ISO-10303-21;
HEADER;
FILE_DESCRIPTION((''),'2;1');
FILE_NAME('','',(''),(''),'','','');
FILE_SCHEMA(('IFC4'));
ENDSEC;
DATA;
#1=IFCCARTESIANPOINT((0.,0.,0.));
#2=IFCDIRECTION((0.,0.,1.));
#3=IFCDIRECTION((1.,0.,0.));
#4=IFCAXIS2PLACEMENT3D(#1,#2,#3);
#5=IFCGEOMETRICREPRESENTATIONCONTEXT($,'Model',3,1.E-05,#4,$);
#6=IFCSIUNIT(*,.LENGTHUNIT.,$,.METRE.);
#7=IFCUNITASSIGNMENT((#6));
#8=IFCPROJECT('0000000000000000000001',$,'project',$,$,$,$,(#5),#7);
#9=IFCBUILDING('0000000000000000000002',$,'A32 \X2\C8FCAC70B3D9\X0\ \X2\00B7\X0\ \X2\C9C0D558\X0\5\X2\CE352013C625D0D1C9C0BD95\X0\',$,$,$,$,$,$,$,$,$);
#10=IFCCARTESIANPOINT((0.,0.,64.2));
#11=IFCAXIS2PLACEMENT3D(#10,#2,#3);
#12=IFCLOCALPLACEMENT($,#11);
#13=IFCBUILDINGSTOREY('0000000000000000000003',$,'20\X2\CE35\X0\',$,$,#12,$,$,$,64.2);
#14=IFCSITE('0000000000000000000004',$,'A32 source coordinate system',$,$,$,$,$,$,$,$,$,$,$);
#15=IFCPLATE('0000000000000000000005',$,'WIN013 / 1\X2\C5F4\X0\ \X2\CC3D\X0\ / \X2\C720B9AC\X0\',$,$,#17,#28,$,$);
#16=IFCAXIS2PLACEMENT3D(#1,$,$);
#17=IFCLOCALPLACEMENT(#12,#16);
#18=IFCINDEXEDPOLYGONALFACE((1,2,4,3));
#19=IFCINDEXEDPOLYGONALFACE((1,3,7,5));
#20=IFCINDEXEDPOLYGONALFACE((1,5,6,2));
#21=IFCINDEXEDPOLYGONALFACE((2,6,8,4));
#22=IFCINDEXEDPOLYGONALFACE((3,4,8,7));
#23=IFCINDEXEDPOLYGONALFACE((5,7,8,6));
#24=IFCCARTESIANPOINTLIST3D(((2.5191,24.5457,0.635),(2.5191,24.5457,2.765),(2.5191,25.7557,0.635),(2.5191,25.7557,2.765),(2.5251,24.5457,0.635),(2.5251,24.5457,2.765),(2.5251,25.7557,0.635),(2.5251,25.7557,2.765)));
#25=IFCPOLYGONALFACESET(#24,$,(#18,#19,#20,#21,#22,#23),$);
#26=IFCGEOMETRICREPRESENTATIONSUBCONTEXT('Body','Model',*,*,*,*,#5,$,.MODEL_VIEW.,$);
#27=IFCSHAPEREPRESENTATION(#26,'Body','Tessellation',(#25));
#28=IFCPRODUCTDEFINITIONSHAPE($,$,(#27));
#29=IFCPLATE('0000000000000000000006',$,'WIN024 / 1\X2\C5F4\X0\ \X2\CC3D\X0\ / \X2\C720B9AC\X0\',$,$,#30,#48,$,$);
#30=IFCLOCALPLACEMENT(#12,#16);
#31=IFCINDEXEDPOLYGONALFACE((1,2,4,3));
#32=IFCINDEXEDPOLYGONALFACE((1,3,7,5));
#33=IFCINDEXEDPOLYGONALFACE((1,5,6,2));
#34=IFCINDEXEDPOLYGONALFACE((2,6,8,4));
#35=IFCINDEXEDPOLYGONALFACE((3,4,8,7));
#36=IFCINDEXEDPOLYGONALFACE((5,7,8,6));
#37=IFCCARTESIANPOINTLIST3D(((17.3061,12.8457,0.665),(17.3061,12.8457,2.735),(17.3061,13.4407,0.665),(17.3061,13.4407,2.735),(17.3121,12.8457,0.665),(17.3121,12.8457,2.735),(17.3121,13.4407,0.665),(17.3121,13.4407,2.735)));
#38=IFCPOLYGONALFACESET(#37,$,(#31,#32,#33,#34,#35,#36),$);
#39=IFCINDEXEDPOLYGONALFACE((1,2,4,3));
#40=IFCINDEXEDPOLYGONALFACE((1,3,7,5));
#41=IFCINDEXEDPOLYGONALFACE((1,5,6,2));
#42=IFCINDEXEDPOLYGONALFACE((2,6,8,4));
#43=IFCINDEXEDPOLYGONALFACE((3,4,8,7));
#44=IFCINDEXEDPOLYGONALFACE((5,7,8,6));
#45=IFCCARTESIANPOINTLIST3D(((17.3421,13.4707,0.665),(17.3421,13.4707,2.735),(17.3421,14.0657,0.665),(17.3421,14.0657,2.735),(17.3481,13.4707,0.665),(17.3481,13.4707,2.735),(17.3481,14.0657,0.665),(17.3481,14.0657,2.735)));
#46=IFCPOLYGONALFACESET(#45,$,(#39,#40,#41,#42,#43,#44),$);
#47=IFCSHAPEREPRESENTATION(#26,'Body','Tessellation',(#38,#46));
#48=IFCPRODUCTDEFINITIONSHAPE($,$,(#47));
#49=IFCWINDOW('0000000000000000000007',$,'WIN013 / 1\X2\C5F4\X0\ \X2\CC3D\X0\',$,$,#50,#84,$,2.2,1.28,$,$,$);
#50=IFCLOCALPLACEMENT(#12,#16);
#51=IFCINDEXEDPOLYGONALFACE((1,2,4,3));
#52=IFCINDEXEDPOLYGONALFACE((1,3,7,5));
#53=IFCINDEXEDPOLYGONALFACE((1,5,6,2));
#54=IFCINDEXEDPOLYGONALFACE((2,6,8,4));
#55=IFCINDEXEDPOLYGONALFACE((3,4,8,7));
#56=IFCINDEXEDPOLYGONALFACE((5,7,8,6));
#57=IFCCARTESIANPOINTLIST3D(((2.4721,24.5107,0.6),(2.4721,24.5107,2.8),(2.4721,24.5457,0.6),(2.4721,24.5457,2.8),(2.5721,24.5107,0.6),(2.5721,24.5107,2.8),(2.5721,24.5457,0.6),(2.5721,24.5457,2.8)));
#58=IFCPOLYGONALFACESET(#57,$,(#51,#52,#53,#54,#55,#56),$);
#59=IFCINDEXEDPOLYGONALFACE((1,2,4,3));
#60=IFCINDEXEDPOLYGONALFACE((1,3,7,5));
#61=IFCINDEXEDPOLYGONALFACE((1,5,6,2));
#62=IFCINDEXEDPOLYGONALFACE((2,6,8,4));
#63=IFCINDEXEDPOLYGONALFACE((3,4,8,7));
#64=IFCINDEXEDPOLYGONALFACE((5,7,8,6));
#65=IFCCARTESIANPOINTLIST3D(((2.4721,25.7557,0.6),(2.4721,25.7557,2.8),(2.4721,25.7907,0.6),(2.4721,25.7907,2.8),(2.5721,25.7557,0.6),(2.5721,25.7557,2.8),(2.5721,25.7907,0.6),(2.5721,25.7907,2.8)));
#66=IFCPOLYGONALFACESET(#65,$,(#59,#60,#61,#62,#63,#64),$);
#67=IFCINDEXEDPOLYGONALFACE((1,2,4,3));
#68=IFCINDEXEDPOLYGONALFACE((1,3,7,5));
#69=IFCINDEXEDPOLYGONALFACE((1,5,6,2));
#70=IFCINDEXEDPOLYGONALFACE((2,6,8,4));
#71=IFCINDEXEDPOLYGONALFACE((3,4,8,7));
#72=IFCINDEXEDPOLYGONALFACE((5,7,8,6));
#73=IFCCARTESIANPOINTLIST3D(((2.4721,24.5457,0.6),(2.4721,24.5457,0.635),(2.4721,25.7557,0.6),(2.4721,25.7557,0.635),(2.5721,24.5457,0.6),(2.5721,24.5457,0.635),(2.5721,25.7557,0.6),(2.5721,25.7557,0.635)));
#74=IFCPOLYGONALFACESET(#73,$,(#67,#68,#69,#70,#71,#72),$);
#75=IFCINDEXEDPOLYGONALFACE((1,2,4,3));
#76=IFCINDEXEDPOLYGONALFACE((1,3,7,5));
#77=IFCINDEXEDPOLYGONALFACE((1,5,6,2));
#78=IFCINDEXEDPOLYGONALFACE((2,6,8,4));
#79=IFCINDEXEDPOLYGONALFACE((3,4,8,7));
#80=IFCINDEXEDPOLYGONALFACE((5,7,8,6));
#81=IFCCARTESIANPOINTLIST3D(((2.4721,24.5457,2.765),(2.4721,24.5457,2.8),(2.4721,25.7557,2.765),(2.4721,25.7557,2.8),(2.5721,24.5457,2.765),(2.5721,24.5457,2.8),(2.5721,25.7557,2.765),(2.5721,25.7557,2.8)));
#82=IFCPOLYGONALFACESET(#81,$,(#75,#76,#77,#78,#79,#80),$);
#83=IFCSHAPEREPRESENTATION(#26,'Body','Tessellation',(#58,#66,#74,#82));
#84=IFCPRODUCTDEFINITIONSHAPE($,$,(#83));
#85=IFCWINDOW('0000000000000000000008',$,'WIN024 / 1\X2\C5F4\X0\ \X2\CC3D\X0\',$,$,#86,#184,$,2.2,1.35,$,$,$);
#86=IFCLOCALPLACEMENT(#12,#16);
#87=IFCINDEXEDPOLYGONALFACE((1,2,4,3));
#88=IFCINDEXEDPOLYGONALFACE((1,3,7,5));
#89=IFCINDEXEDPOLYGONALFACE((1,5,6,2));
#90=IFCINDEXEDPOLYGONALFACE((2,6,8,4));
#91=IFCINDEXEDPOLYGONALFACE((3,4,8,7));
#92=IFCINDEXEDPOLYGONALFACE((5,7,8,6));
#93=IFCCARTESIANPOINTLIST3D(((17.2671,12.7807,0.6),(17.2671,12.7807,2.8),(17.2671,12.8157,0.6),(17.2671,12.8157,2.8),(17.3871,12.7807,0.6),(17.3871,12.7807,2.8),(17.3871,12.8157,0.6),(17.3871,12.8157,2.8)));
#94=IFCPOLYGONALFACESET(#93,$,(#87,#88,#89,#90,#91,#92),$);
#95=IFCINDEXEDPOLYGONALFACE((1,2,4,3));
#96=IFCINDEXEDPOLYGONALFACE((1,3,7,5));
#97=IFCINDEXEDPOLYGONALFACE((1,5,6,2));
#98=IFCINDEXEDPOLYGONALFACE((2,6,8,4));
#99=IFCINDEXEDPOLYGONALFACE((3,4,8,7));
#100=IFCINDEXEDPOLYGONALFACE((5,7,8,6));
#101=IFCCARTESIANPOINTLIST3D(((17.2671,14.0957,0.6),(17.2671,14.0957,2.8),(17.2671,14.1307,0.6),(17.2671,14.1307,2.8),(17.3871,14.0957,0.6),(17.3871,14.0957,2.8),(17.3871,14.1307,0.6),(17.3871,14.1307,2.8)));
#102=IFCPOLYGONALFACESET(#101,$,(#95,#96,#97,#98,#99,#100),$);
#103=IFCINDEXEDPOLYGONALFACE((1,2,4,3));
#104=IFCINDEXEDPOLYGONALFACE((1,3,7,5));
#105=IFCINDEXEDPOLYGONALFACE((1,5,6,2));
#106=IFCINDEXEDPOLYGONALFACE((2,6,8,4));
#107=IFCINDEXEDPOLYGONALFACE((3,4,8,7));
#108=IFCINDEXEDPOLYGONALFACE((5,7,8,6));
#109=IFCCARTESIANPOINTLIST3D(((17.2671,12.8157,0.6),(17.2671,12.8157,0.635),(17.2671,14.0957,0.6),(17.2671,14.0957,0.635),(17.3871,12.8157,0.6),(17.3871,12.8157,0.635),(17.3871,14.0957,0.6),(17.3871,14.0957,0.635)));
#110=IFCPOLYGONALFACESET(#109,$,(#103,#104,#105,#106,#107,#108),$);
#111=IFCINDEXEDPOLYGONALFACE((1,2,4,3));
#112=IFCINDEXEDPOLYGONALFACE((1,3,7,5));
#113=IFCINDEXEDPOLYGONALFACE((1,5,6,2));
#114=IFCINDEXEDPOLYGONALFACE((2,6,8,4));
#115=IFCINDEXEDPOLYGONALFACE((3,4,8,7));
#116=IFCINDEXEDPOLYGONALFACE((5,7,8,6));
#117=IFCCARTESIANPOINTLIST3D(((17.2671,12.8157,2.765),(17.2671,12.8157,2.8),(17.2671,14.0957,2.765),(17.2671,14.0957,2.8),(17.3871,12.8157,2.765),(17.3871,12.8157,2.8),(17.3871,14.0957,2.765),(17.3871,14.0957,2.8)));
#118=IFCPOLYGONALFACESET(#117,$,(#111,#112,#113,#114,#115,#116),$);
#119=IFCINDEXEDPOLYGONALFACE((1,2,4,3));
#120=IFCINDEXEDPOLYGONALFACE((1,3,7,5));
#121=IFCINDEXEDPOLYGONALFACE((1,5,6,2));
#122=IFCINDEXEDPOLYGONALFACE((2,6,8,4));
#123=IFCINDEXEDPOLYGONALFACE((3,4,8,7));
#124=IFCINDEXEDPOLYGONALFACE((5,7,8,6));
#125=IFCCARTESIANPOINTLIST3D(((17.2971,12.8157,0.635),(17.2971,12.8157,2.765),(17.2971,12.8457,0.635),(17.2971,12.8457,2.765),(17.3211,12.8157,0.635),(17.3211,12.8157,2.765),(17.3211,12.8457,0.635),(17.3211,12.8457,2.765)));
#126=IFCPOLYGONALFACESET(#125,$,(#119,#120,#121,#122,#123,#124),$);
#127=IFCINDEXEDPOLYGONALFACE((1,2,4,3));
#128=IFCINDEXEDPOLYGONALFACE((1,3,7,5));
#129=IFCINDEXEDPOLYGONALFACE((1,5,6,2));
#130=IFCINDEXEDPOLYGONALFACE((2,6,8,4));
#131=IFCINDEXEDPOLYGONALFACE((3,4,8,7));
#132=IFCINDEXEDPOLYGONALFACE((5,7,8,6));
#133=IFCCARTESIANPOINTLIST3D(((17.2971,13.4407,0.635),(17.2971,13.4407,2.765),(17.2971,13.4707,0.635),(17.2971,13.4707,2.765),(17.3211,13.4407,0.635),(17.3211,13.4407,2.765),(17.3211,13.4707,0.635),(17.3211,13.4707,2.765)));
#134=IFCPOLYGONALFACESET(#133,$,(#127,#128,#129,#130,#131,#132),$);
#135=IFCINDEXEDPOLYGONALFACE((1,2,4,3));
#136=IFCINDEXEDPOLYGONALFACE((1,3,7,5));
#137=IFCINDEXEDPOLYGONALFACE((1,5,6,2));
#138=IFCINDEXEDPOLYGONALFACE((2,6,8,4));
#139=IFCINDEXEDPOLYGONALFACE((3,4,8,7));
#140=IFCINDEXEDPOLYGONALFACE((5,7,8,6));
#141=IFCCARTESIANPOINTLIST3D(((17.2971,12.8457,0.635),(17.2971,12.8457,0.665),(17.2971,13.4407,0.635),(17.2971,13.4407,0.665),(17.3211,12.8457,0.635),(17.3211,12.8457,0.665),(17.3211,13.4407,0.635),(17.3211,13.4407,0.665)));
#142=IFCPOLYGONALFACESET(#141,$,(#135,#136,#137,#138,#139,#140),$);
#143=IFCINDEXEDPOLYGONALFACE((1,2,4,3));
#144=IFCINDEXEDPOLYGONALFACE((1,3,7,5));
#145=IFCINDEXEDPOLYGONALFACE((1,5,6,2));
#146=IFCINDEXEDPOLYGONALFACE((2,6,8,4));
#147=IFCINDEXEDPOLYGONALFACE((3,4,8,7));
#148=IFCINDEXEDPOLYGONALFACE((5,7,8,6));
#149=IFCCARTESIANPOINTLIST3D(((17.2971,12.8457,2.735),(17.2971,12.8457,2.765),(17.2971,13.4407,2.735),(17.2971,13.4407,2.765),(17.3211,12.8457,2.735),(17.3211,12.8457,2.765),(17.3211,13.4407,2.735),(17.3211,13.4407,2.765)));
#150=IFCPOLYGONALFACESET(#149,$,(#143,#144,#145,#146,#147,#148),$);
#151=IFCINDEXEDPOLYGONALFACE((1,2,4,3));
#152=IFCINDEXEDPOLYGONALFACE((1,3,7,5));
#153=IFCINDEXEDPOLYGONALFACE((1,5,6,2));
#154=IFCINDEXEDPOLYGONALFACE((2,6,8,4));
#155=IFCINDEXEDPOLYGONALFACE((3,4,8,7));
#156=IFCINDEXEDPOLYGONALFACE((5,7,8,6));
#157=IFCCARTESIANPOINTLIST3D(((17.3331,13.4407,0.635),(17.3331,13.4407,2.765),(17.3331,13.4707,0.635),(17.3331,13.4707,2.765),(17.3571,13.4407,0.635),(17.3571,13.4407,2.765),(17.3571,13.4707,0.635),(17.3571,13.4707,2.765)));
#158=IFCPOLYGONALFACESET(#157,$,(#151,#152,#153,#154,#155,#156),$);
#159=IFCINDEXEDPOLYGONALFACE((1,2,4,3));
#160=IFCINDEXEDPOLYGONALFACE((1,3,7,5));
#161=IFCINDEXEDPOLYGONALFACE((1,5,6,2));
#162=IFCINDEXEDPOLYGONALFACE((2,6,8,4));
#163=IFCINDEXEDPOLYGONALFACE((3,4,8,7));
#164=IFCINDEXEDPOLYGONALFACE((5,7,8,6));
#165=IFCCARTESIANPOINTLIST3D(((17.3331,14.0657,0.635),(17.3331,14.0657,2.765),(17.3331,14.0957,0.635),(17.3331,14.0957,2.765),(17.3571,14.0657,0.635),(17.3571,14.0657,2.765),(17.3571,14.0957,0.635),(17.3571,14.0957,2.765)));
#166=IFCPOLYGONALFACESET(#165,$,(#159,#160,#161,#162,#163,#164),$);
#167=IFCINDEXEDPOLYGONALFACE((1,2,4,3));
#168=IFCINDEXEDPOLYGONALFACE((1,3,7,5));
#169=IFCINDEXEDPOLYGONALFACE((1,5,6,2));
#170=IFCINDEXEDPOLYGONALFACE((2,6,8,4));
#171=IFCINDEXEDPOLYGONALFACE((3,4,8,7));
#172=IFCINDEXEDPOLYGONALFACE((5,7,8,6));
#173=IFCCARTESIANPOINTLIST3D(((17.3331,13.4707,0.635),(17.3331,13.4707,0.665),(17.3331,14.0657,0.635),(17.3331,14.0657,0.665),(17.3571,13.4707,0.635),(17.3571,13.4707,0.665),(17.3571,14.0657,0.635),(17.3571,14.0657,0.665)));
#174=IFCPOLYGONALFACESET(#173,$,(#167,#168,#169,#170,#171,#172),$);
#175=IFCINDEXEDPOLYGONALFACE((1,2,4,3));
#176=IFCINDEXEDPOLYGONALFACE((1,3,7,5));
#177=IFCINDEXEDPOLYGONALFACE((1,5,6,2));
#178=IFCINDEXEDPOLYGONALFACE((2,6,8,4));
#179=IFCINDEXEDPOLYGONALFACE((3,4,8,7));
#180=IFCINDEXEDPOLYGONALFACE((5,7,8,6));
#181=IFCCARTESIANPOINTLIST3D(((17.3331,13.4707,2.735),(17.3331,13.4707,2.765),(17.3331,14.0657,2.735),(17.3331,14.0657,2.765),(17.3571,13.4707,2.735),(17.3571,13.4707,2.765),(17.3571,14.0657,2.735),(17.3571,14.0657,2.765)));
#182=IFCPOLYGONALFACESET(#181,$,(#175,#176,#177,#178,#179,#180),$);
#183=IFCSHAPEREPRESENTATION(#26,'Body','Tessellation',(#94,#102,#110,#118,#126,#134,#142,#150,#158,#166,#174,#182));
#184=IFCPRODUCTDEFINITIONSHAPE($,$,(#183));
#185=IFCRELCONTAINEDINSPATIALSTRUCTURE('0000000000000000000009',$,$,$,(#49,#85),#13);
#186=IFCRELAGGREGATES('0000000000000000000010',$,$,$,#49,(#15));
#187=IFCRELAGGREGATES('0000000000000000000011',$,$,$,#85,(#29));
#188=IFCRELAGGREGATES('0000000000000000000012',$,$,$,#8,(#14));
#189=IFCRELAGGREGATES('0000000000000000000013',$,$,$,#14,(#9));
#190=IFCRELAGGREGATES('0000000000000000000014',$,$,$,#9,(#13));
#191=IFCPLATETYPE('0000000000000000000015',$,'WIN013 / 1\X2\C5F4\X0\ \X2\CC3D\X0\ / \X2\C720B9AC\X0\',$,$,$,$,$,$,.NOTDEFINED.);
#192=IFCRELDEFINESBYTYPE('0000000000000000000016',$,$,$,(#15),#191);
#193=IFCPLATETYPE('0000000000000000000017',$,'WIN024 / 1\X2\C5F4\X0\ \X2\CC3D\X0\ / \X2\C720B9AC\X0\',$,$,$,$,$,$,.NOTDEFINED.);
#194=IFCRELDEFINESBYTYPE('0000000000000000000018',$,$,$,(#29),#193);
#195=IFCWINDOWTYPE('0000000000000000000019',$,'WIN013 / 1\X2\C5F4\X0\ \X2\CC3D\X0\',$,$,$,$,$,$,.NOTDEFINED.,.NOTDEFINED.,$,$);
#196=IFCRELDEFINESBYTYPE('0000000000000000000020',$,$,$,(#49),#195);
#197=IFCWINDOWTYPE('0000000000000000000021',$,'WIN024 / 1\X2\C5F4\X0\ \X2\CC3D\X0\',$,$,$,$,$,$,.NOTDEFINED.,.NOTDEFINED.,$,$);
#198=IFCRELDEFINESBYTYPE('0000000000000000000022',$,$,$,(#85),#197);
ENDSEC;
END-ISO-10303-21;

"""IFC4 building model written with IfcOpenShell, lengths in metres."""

from ifc_helpers import new_model, si_unit, frame, origin, origin_with_axes, place, context, subcontext, project, spatial, polyline, outline, extrude, source, transform, mapped, type_object, type_shapes, element, aggregate, save


model = new_model("IFC4")

# Units and contexts
model_context = context("Model", 3, precision=1e-05, world=origin_with_axes())
body_context = subcontext(model_context, "Body", "Model", "MODEL_VIEW")
ifc_project = project(units=[si_unit("LENGTHUNIT", "METRE")], contexts=[model_context])

# Plates
plate_type_1 = type_object("IfcPlateType", Name="WIN013 / 1열 창 / 유리", PredefinedType="NOTDEFINED")
shared_shape_1 = source(origin(), body_context, "Body", "SweptSolid", [
    extrude(outline(polyline([(2.5191, 24.5457), (2.5191, 25.7557), (2.5251, 25.7557), (2.5251, 24.5457), (2.5191, 24.5457)])), frame((0.0, 0.0, 0.635)), (0.0, 0.0, 1.0), 2.13),
])
type_shapes(plate_type_1, [shared_shape_1])
storey_placement = place(None, frame((0.0, 0.0, 64.2), z_axis=(0.0, 0.0, 1.0), x_axis=(1.0, 0.0, 0.0)))
window_1_placement = place(storey_placement, origin_with_axes())
plate_1_placement = place(window_1_placement, origin_with_axes())
plate_1 = element("IfcPlate", 1, at=plate_1_placement, type_object=plate_type_1, Name="WIN013 / 1열 창 / 유리", context=body_context, shape_type="MappedRepresentation", body=[
    mapped(shared_shape_1, transform((0.0, 0.0, 0.0), scale=1.0)),
])
plate_type_2 = type_object("IfcPlateType", Name="WIN024 / 1열 창 / 유리", PredefinedType="NOTDEFINED")
shared_shape_2 = source(origin(), body_context, "Body", "SweptSolid", [
    extrude(outline(polyline([(17.3061, 12.8457), (17.3061, 13.4407), (17.3121, 13.4407), (17.3121, 12.8457), (17.3061, 12.8457)])), frame((0.0, 0.0, 0.665)), (0.0, 0.0, 1.0), 2.07),
    extrude(outline(polyline([(17.3421, 13.4707), (17.3421, 14.0657), (17.3481, 14.0657), (17.3481, 13.4707), (17.3421, 13.4707)])), frame((0.0, 0.0, 0.665)), (0.0, 0.0, 1.0), 2.07),
])
type_shapes(plate_type_2, [shared_shape_2])
window_2_placement = place(storey_placement, origin_with_axes())
plate_2_placement = place(window_2_placement, origin_with_axes())
plate_2 = element("IfcPlate", 2, at=plate_2_placement, type_object=plate_type_2, Name="WIN024 / 1열 창 / 유리", context=body_context, shape_type="MappedRepresentation", body=[
    mapped(shared_shape_2, transform((0.0, 0.0, 0.0), scale=1.0)),
])

# Site, building, storey
site = spatial("IfcSite", under=ifc_project, Name="A32 source coordinate system")
building = spatial("IfcBuilding", under=site, Name="A32 주거동 · 지하5층–옥탑지붕")
storey = spatial("IfcBuildingStorey", under=building, at=storey_placement, Name="20층", Elevation=64.2)

# Windows
window_type_1 = type_object("IfcWindowType", Name="WIN013 / 1열 창", PartitioningType="NOTDEFINED", PredefinedType="NOTDEFINED")
shared_shape_3 = source(origin(), body_context, "Body", "SweptSolid", [
    extrude(outline(polyline([(2.4721, 24.5107), (2.4721, 24.5457), (2.5721, 24.5457), (2.5721, 24.5107), (2.4721, 24.5107)])), frame((0.0, 0.0, 0.6)), (0.0, 0.0, 1.0), 2.2),
    extrude(outline(polyline([(2.4721, 25.7557), (2.4721, 25.7907), (2.5721, 25.7907), (2.5721, 25.7557), (2.4721, 25.7557)])), frame((0.0, 0.0, 0.6)), (0.0, 0.0, 1.0), 2.2),
    extrude(outline(polyline([(2.4721, 24.5457), (2.4721, 25.7557), (2.5721, 25.7557), (2.5721, 24.5457), (2.4721, 24.5457)])), frame((0.0, 0.0, 0.6)), (0.0, 0.0, 1.0), 0.035),
    extrude(outline(polyline([(2.4721, 24.5457), (2.4721, 25.7557), (2.5721, 25.7557), (2.5721, 24.5457), (2.4721, 24.5457)])), frame((0.0, 0.0, 2.765)), (0.0, 0.0, 1.0), 0.035),
])
type_shapes(window_type_1, [shared_shape_3])
window_1 = element("IfcWindow", 3, at=window_1_placement, inside=storey, type_object=window_type_1, Name="WIN013 / 1열 창", OverallHeight=2.2, OverallWidth=1.28, context=body_context, shape_type="MappedRepresentation", body=[
    mapped(shared_shape_3, transform((0.0, 0.0, 0.0), scale=1.0)),
])
aggregate(window_1, [plate_1])
window_type_2 = type_object("IfcWindowType", Name="WIN024 / 1열 창", PartitioningType="NOTDEFINED", PredefinedType="NOTDEFINED")
shared_shape_4 = source(origin(), body_context, "Body", "SweptSolid", [
    extrude(outline(polyline([(17.2671, 12.7807), (17.2671, 12.8157), (17.3871, 12.8157), (17.3871, 12.7807), (17.2671, 12.7807)])), frame((0.0, 0.0, 0.6)), (0.0, 0.0, 1.0), 2.2),
    extrude(outline(polyline([(17.2671, 14.0957), (17.2671, 14.1307), (17.3871, 14.1307), (17.3871, 14.0957), (17.2671, 14.0957)])), frame((0.0, 0.0, 0.6)), (0.0, 0.0, 1.0), 2.2),
    extrude(outline(polyline([(17.2671, 12.8157), (17.2671, 14.0957), (17.3871, 14.0957), (17.3871, 12.8157), (17.2671, 12.8157)])), frame((0.0, 0.0, 0.6)), (0.0, 0.0, 1.0), 0.035),
    extrude(outline(polyline([(17.2671, 12.8157), (17.2671, 14.0957), (17.3871, 14.0957), (17.3871, 12.8157), (17.2671, 12.8157)])), frame((0.0, 0.0, 2.765)), (0.0, 0.0, 1.0), 0.035),
    extrude(outline(polyline([(17.2971, 12.8157), (17.2971, 12.8457), (17.3211, 12.8457), (17.3211, 12.8157), (17.2971, 12.8157)])), frame((0.0, 0.0, 0.635)), (0.0, 0.0, 1.0), 2.13),
    extrude(outline(polyline([(17.2971, 13.4407), (17.2971, 13.4707), (17.3211, 13.4707), (17.3211, 13.4407), (17.2971, 13.4407)])), frame((0.0, 0.0, 0.635)), (0.0, 0.0, 1.0), 2.13),
    extrude(outline(polyline([(17.2971, 12.8457), (17.2971, 13.4407), (17.3211, 13.4407), (17.3211, 12.8457), (17.2971, 12.8457)])), frame((0.0, 0.0, 0.635)), (0.0, 0.0, 1.0), 0.03),
    extrude(outline(polyline([(17.2971, 12.8457), (17.2971, 13.4407), (17.3211, 13.4407), (17.3211, 12.8457), (17.2971, 12.8457)])), frame((0.0, 0.0, 2.735)), (0.0, 0.0, 1.0), 0.03),
    extrude(outline(polyline([(17.3331, 13.4407), (17.3331, 13.4707), (17.3571, 13.4707), (17.3571, 13.4407), (17.3331, 13.4407)])), frame((0.0, 0.0, 0.635)), (0.0, 0.0, 1.0), 2.13),
    extrude(outline(polyline([(17.3331, 14.0657), (17.3331, 14.0957), (17.3571, 14.0957), (17.3571, 14.0657), (17.3331, 14.0657)])), frame((0.0, 0.0, 0.635)), (0.0, 0.0, 1.0), 2.13),
    extrude(outline(polyline([(17.3331, 13.4707), (17.3331, 14.0657), (17.3571, 14.0657), (17.3571, 13.4707), (17.3331, 13.4707)])), frame((0.0, 0.0, 0.635)), (0.0, 0.0, 1.0), 0.03),
    extrude(outline(polyline([(17.3331, 13.4707), (17.3331, 14.0657), (17.3571, 14.0657), (17.3571, 13.4707), (17.3331, 13.4707)])), frame((0.0, 0.0, 2.735)), (0.0, 0.0, 1.0), 0.03),
])
type_shapes(window_type_2, [shared_shape_4])
window_2 = element("IfcWindow", 4, at=window_2_placement, inside=storey, type_object=window_type_2, Name="WIN024 / 1열 창", OverallHeight=2.2, OverallWidth=1.35, context=body_context, shape_type="MappedRepresentation", body=[
    mapped(shared_shape_4, transform((0.0, 0.0, 0.0), scale=1.0)),
])
aggregate(window_2, [plate_2])

save(model, "model.ifc")
